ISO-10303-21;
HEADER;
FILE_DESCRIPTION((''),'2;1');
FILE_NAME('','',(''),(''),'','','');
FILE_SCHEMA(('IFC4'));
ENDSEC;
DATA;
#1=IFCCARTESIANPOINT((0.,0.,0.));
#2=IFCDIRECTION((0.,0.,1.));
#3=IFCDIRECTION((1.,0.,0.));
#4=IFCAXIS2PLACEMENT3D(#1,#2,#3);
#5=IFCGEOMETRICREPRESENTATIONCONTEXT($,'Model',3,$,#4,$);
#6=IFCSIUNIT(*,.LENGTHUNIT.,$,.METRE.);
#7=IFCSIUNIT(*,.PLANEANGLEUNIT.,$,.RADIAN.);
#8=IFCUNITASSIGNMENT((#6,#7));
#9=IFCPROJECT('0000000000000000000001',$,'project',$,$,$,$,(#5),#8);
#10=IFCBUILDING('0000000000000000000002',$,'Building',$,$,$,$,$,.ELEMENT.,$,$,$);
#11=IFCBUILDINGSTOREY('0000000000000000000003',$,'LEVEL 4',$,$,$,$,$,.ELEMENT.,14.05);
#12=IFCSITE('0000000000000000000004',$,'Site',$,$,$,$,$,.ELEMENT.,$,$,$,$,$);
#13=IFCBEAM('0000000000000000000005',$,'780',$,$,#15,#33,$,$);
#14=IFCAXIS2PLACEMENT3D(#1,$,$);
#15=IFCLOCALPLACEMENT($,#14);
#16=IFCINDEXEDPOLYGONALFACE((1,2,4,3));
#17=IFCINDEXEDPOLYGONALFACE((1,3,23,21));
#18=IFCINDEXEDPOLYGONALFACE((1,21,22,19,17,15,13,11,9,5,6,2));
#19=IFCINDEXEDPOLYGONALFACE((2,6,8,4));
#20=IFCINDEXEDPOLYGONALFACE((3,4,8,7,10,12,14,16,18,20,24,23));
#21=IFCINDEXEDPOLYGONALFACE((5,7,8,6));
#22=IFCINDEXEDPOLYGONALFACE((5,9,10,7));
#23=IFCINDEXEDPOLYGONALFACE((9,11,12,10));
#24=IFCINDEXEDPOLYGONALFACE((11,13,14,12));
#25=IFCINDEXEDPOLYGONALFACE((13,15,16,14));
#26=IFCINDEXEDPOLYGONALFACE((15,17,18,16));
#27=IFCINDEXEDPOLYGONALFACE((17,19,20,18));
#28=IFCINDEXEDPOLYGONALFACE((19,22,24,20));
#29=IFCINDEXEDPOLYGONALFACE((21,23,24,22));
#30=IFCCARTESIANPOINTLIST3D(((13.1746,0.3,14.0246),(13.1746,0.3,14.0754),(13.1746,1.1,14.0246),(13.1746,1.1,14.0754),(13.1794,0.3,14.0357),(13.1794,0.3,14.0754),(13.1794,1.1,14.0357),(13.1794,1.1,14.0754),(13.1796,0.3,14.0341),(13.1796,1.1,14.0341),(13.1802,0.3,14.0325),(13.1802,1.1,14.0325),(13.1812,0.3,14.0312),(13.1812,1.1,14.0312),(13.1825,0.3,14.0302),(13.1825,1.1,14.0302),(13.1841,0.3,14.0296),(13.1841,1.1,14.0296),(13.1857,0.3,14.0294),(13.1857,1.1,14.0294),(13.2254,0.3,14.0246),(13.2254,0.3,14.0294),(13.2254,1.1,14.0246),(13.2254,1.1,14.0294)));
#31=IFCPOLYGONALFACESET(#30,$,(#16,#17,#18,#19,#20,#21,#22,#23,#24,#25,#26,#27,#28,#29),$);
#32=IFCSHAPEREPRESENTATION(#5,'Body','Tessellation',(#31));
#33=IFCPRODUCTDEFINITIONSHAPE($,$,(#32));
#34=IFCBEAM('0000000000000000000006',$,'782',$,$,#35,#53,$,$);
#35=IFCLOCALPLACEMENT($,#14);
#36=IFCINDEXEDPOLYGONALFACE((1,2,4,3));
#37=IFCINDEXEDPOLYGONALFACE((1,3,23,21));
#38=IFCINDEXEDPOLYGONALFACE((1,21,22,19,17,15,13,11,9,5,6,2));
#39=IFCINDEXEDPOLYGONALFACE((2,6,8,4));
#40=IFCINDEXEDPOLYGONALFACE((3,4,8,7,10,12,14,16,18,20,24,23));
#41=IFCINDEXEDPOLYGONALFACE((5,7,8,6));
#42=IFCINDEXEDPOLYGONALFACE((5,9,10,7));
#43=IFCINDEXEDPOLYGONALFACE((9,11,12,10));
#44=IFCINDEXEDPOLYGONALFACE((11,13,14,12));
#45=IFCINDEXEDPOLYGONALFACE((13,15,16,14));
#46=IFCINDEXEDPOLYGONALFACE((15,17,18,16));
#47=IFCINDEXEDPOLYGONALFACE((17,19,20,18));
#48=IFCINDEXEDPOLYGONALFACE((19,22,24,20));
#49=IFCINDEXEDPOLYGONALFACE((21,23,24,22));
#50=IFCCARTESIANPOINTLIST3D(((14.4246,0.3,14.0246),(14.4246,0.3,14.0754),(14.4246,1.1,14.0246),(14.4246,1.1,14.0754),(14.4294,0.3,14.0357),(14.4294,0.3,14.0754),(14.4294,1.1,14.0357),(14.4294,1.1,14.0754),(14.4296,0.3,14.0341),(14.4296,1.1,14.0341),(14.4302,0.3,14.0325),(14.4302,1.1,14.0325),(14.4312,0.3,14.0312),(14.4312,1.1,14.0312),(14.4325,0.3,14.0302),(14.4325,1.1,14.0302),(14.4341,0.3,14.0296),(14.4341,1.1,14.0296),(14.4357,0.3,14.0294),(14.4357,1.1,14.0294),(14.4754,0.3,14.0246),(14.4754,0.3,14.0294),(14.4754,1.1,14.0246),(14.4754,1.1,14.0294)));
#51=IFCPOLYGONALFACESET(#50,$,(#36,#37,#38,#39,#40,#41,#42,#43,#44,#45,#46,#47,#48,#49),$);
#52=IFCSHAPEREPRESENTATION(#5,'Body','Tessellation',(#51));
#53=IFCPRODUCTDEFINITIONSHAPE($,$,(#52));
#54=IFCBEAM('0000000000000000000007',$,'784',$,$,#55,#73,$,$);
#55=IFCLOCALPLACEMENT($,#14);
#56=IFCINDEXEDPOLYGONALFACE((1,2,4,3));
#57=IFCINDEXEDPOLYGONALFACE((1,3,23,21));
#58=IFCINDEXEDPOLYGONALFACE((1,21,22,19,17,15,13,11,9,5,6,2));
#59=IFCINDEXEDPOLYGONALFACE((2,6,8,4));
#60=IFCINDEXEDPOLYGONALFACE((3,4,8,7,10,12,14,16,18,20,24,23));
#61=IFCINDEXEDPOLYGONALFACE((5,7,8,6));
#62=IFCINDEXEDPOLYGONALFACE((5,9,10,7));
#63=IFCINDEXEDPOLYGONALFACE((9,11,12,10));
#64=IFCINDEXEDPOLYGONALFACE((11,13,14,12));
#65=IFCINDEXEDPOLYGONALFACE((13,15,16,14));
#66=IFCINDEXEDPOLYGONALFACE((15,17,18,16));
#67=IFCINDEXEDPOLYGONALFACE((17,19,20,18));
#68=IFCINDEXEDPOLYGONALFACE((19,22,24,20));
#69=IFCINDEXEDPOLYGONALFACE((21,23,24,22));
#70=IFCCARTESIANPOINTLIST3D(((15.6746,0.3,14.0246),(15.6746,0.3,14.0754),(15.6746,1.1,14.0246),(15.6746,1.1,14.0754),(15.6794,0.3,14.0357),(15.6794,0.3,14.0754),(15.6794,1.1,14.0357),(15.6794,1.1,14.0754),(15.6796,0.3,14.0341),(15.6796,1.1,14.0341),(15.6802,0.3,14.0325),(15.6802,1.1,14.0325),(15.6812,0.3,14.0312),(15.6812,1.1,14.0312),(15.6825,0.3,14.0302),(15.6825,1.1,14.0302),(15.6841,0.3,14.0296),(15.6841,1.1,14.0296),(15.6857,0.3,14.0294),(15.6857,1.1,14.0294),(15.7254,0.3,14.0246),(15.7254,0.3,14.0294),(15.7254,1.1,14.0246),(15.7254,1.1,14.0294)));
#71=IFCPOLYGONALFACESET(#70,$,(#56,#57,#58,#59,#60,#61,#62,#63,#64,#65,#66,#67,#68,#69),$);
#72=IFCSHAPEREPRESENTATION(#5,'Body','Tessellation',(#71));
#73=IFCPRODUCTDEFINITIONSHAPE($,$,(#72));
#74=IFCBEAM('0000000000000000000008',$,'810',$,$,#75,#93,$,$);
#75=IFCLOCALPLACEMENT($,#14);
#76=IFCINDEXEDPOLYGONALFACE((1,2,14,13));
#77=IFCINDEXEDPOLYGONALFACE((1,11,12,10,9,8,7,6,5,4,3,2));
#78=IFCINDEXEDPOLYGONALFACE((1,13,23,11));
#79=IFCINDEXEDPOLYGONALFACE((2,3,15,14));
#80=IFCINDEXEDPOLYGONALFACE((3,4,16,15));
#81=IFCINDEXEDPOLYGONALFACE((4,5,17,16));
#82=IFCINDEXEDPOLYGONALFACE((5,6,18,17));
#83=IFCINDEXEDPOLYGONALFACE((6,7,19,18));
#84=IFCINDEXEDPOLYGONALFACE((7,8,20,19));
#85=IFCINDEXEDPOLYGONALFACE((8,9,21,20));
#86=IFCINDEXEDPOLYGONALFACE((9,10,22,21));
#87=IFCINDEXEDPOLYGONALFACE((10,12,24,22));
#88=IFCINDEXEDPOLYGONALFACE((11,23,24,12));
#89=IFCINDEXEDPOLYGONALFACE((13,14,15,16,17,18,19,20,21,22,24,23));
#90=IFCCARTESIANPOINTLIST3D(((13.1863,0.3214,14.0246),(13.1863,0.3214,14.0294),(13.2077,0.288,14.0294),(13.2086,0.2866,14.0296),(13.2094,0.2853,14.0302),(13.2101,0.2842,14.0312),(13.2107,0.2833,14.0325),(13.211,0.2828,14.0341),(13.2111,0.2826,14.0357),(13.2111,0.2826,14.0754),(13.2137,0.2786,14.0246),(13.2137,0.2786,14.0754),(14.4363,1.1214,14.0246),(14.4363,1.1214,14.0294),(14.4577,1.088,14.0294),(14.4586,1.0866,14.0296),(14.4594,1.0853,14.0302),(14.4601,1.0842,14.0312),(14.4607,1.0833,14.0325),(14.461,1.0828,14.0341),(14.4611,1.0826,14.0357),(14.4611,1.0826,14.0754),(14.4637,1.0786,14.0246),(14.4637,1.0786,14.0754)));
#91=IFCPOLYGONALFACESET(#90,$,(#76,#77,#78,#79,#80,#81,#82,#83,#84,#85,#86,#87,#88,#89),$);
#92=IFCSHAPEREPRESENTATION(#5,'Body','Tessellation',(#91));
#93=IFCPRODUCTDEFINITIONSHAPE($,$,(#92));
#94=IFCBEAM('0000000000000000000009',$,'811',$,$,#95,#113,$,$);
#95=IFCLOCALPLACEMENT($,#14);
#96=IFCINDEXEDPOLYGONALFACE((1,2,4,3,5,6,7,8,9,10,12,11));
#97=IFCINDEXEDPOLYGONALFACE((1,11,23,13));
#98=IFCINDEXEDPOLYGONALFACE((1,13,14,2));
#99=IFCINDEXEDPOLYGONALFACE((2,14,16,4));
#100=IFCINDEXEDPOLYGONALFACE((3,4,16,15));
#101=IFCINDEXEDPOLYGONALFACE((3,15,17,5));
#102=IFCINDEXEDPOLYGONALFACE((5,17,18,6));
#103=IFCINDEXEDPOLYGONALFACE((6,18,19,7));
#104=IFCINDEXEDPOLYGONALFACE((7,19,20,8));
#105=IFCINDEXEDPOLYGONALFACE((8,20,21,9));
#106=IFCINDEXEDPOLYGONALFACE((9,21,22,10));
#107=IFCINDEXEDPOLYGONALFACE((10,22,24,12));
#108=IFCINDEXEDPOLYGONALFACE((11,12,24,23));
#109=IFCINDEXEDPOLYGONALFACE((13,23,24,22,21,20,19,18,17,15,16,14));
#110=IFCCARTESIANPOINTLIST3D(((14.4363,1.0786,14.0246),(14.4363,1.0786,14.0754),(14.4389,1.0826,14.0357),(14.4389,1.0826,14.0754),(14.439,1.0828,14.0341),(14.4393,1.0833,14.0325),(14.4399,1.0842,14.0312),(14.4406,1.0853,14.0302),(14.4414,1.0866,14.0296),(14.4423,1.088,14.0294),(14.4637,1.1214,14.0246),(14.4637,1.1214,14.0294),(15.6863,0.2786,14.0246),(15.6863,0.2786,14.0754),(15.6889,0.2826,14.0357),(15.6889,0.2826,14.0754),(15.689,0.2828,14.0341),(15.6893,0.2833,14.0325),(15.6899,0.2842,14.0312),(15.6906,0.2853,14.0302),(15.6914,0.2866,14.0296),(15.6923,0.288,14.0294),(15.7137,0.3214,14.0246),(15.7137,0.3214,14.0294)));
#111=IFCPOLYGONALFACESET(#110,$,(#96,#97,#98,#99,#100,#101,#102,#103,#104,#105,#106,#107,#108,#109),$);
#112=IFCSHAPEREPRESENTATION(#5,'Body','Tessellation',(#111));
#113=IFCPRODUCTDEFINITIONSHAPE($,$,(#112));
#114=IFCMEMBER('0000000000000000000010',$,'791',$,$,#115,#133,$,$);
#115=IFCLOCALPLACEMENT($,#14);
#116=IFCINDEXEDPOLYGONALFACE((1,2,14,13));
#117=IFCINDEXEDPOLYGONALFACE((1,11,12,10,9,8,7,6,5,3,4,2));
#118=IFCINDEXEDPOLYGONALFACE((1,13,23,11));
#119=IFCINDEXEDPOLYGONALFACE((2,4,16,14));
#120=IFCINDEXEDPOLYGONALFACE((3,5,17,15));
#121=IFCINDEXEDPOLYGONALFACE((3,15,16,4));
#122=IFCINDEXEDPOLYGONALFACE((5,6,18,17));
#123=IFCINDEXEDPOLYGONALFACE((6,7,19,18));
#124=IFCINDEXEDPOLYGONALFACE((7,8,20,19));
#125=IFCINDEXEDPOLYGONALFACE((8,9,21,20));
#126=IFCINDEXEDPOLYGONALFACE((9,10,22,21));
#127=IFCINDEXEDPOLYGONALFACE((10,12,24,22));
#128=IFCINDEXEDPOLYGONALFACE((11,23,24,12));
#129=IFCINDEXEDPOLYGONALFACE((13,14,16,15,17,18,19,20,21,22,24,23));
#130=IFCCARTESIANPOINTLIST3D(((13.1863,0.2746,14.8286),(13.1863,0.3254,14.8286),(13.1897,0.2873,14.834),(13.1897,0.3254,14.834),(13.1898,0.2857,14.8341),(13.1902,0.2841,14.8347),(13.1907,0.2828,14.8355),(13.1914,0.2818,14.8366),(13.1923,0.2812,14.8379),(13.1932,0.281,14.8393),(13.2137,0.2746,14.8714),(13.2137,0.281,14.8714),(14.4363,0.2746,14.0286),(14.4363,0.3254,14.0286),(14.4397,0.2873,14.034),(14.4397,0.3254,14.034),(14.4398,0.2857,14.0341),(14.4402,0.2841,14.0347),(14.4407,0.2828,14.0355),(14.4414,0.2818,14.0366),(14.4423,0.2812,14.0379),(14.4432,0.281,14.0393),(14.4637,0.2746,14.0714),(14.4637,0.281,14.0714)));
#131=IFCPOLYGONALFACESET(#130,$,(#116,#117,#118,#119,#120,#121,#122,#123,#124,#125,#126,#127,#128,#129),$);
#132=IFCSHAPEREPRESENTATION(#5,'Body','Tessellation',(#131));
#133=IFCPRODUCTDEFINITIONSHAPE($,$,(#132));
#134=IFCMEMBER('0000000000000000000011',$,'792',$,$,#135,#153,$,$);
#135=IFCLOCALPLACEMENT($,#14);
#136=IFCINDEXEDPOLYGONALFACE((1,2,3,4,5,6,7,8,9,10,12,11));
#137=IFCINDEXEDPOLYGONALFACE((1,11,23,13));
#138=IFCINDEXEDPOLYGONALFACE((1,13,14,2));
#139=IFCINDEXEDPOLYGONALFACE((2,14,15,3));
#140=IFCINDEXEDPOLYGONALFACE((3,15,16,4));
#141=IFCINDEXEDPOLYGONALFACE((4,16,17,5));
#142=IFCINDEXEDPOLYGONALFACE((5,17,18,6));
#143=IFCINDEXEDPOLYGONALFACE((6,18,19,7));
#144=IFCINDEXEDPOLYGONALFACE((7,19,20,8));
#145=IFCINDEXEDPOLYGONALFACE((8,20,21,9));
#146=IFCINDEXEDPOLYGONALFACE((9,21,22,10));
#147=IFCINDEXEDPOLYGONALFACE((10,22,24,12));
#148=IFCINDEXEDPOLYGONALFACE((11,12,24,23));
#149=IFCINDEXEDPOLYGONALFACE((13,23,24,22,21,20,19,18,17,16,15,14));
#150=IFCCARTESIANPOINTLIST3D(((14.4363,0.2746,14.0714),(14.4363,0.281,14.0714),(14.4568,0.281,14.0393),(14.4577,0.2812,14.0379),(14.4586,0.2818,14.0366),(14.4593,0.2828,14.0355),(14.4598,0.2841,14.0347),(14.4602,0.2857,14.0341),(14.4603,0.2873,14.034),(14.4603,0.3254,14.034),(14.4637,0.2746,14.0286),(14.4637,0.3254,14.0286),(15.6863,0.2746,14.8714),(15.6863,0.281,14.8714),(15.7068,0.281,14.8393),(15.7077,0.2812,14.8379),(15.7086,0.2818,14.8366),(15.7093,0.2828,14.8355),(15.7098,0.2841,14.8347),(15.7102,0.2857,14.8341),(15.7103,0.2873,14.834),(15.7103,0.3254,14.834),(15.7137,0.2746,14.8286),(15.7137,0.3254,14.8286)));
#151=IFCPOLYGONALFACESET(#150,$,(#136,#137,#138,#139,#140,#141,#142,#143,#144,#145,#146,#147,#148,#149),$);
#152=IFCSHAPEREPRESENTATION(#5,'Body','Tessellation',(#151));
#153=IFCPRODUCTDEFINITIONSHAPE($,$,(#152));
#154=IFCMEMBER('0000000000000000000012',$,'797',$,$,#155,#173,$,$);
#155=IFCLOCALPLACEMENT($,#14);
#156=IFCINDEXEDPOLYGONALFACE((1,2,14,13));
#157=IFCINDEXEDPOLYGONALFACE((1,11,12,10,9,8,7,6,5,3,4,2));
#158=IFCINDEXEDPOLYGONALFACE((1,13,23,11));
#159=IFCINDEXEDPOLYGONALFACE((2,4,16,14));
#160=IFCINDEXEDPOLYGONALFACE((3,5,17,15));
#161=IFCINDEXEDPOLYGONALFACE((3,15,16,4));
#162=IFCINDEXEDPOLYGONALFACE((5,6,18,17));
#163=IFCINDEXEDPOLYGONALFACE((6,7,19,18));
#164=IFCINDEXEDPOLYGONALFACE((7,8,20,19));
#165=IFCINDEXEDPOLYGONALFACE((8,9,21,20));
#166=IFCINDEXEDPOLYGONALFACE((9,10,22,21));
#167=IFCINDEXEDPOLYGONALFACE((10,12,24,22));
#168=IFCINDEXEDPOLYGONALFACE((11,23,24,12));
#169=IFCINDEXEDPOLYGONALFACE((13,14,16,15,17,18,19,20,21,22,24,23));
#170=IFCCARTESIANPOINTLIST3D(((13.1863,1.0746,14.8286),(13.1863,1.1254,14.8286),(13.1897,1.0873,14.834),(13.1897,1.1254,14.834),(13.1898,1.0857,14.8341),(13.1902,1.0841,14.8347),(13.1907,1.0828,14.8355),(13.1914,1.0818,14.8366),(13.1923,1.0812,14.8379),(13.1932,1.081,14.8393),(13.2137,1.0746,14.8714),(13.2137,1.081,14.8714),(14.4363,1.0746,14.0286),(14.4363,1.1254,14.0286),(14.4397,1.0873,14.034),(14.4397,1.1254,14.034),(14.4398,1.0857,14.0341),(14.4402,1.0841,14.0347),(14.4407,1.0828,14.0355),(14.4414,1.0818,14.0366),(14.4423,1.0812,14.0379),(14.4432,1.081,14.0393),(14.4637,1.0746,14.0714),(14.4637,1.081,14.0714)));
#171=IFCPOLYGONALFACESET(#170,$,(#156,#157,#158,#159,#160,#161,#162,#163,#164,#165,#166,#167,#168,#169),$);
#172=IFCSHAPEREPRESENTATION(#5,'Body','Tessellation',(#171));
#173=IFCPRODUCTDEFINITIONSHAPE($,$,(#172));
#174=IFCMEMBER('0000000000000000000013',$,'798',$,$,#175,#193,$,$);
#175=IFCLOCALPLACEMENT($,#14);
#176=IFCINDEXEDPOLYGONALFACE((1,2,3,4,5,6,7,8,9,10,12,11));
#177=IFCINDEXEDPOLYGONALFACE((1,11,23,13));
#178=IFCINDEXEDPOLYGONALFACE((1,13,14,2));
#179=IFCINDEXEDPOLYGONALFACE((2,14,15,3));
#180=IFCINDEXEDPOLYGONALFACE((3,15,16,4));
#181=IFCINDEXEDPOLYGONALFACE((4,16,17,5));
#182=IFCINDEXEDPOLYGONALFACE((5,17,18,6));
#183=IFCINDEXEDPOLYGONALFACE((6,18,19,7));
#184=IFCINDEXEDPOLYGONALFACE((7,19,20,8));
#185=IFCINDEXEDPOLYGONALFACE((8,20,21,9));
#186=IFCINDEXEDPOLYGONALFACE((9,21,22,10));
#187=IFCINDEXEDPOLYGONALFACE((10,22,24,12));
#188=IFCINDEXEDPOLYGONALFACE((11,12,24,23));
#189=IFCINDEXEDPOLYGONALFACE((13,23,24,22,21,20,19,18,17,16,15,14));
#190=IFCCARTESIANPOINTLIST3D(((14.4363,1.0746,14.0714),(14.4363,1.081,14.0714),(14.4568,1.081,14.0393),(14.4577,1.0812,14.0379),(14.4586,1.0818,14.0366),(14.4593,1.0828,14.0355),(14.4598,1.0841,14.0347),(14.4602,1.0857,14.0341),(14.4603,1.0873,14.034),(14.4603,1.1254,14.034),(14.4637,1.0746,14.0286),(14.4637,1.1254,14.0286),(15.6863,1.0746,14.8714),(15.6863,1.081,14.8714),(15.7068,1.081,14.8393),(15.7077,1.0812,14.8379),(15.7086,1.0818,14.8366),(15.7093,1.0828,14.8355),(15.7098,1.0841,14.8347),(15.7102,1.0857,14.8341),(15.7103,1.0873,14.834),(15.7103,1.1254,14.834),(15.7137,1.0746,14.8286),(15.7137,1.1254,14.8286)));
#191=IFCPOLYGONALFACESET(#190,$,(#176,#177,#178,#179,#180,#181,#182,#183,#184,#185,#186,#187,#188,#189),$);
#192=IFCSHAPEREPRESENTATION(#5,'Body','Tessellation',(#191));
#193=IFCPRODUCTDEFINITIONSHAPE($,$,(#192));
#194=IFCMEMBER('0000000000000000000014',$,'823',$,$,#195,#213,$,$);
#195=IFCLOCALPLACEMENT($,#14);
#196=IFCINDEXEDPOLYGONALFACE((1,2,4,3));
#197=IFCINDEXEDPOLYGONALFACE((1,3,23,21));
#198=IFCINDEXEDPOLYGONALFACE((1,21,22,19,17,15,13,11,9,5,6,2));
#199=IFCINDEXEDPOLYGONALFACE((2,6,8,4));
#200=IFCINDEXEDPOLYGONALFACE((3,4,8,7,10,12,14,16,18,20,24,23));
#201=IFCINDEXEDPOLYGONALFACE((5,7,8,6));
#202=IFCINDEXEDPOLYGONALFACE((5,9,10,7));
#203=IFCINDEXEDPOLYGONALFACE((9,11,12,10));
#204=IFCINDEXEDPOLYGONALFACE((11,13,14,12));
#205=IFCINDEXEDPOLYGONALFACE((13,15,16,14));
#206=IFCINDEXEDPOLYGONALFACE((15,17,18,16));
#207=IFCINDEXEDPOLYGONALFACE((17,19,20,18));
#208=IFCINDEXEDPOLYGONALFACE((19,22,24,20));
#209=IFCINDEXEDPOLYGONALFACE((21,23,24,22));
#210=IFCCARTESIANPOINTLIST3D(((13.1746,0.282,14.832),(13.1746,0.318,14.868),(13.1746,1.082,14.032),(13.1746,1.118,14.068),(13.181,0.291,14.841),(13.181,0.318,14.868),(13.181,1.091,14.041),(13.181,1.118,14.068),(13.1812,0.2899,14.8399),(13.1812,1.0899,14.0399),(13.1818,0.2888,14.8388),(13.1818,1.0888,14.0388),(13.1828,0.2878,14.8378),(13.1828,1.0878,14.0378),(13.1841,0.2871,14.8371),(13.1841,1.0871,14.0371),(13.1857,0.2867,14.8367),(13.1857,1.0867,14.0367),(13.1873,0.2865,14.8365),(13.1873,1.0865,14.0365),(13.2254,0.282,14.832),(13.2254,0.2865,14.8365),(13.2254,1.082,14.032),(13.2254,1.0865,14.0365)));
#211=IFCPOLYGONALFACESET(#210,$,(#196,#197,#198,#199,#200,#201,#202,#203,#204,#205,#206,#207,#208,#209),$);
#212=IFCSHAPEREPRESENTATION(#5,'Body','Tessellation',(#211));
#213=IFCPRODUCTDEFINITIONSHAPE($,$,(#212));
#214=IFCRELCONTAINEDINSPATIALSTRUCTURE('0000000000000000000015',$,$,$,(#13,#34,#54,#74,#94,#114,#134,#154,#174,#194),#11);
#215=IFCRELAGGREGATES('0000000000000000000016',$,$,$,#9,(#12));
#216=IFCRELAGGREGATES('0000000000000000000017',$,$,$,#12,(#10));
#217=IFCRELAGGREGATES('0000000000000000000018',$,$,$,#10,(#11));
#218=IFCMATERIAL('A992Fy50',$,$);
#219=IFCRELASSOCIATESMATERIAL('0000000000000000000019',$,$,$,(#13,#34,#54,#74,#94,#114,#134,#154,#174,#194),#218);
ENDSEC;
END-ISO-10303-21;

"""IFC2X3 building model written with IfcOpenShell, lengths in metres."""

from ifc_helpers import new_model, si_unit, frame, origin_with_axes, origin_2d_with_axis, place, context, project, spatial, l_section, extrude, material, element, save


model = new_model("IFC2X3")

# Units and contexts
model_context = context("Model", 3, world=origin_with_axes())
ifc_project = project(units=[si_unit("LENGTHUNIT", "METRE"), si_unit("PLANEANGLEUNIT", "RADIAN")], contexts=[model_context])

# Site, building, storey
site = spatial("IfcSite", under=ifc_project, Name="Site", CompositionType="ELEMENT")
building = spatial("IfcBuilding", under=site, Name="Building", CompositionType="ELEMENT")
storey = spatial("IfcBuildingStorey", under=building, Name="LEVEL 4", CompositionType="ELEMENT", Elevation=14.05)

# Shared definitions
ifc_material = material(Name="A992Fy50")

# Beams
for number, where, z_axis, x_axis, name in (
    (1, (13.2, 1.1, 14.05), (0.0, -1.0, 0.0), (1.0, 0.0, 0.0), "780"),
    (2, (14.45, 1.1, 14.05), (0.0, -1.0, 0.0), (1.0, 0.0, 0.0), "782"),
    (3, (15.7, 1.1, 14.05), (0.0, -1.0, 0.0), (1.0, 0.0, 0.0), "784"),
):
    element("IfcBeam", number, at=place(None, frame(where, z_axis=z_axis, x_axis=x_axis)), inside=storey, material=ifc_material, Name=name, context=model_context, shape_type="SweptSolid", body=[
        extrude(l_section(Depth=0.0508, Width=0.0508, Thickness=0.0048, FilletRadius=0.0063, at=origin_2d_with_axis()), origin_with_axes(), (0.0, 0.0, 1.0), 0.8),
    ])
for number, where, z_axis, x_axis, name in (
    (4, (13.2, 0.3, 14.05), (0.842271, 0.539054, 0.0), (-0.539054, 0.842271, 0.0), "810"),
    (5, (14.45, 1.1, 14.05), (0.842271, -0.539054, 0.0), (0.539054, 0.842271, 0.0), "811"),
):
    element("IfcBeam", number, at=place(None, frame(where, z_axis=z_axis, x_axis=x_axis)), inside=storey, material=ifc_material, Name=name, context=model_context, shape_type="SweptSolid", body=[
        extrude(l_section(Depth=0.0508, Width=0.0508, Thickness=0.0048, FilletRadius=0.0063, at=origin_2d_with_axis()), origin_with_axes(), (0.0, 0.0, 1.0), 1.4841),
    ])

# Members
for number, where, z_axis, x_axis, name in (
    (6, (13.2, 0.3, 14.85), (0.842271, 0.0, -0.539054), (0.0, 1.0, 0.0), "791"),
    (7, (14.45, 0.3, 14.05), (0.842271, 0.0, 0.539054), (0.0, 1.0, 0.0), "792"),
    (8, (13.2, 1.1, 14.85), (0.842271, 0.0, -0.539054), (0.0, 1.0, 0.0), "797"),
    (9, (14.45, 1.1, 14.05), (0.842271, 0.0, 0.539054), (0.0, 1.0, 0.0), "798"),
):
    element("IfcMember", number, at=place(None, frame(where, z_axis=z_axis, x_axis=x_axis)), inside=storey, material=ifc_material, Name=name, context=model_context, shape_type="SweptSolid", body=[
        extrude(l_section(Depth=0.0508, Width=0.0508, Thickness=0.0063, FilletRadius=0.0063, at=origin_2d_with_axis()), origin_with_axes(), (0.0, 0.0, 1.0), 1.4841),
    ])
for number, where, z_axis, x_axis, name in (
    (10, (13.2, 1.1, 14.05), (0.0, -0.707107, 0.707107), (1.0, 0.0, 0.0), "823"),
):
    element("IfcMember", number, at=place(None, frame(where, z_axis=z_axis, x_axis=x_axis)), inside=storey, material=ifc_material, Name=name, context=model_context, shape_type="SweptSolid", body=[
        extrude(l_section(Depth=0.0508, Width=0.0508, Thickness=0.0063, FilletRadius=0.0063, at=origin_2d_with_axis()), origin_with_axes(), (0.0, 0.0, 1.0), 1.1314),
    ])

save(model, "model.ifc")
